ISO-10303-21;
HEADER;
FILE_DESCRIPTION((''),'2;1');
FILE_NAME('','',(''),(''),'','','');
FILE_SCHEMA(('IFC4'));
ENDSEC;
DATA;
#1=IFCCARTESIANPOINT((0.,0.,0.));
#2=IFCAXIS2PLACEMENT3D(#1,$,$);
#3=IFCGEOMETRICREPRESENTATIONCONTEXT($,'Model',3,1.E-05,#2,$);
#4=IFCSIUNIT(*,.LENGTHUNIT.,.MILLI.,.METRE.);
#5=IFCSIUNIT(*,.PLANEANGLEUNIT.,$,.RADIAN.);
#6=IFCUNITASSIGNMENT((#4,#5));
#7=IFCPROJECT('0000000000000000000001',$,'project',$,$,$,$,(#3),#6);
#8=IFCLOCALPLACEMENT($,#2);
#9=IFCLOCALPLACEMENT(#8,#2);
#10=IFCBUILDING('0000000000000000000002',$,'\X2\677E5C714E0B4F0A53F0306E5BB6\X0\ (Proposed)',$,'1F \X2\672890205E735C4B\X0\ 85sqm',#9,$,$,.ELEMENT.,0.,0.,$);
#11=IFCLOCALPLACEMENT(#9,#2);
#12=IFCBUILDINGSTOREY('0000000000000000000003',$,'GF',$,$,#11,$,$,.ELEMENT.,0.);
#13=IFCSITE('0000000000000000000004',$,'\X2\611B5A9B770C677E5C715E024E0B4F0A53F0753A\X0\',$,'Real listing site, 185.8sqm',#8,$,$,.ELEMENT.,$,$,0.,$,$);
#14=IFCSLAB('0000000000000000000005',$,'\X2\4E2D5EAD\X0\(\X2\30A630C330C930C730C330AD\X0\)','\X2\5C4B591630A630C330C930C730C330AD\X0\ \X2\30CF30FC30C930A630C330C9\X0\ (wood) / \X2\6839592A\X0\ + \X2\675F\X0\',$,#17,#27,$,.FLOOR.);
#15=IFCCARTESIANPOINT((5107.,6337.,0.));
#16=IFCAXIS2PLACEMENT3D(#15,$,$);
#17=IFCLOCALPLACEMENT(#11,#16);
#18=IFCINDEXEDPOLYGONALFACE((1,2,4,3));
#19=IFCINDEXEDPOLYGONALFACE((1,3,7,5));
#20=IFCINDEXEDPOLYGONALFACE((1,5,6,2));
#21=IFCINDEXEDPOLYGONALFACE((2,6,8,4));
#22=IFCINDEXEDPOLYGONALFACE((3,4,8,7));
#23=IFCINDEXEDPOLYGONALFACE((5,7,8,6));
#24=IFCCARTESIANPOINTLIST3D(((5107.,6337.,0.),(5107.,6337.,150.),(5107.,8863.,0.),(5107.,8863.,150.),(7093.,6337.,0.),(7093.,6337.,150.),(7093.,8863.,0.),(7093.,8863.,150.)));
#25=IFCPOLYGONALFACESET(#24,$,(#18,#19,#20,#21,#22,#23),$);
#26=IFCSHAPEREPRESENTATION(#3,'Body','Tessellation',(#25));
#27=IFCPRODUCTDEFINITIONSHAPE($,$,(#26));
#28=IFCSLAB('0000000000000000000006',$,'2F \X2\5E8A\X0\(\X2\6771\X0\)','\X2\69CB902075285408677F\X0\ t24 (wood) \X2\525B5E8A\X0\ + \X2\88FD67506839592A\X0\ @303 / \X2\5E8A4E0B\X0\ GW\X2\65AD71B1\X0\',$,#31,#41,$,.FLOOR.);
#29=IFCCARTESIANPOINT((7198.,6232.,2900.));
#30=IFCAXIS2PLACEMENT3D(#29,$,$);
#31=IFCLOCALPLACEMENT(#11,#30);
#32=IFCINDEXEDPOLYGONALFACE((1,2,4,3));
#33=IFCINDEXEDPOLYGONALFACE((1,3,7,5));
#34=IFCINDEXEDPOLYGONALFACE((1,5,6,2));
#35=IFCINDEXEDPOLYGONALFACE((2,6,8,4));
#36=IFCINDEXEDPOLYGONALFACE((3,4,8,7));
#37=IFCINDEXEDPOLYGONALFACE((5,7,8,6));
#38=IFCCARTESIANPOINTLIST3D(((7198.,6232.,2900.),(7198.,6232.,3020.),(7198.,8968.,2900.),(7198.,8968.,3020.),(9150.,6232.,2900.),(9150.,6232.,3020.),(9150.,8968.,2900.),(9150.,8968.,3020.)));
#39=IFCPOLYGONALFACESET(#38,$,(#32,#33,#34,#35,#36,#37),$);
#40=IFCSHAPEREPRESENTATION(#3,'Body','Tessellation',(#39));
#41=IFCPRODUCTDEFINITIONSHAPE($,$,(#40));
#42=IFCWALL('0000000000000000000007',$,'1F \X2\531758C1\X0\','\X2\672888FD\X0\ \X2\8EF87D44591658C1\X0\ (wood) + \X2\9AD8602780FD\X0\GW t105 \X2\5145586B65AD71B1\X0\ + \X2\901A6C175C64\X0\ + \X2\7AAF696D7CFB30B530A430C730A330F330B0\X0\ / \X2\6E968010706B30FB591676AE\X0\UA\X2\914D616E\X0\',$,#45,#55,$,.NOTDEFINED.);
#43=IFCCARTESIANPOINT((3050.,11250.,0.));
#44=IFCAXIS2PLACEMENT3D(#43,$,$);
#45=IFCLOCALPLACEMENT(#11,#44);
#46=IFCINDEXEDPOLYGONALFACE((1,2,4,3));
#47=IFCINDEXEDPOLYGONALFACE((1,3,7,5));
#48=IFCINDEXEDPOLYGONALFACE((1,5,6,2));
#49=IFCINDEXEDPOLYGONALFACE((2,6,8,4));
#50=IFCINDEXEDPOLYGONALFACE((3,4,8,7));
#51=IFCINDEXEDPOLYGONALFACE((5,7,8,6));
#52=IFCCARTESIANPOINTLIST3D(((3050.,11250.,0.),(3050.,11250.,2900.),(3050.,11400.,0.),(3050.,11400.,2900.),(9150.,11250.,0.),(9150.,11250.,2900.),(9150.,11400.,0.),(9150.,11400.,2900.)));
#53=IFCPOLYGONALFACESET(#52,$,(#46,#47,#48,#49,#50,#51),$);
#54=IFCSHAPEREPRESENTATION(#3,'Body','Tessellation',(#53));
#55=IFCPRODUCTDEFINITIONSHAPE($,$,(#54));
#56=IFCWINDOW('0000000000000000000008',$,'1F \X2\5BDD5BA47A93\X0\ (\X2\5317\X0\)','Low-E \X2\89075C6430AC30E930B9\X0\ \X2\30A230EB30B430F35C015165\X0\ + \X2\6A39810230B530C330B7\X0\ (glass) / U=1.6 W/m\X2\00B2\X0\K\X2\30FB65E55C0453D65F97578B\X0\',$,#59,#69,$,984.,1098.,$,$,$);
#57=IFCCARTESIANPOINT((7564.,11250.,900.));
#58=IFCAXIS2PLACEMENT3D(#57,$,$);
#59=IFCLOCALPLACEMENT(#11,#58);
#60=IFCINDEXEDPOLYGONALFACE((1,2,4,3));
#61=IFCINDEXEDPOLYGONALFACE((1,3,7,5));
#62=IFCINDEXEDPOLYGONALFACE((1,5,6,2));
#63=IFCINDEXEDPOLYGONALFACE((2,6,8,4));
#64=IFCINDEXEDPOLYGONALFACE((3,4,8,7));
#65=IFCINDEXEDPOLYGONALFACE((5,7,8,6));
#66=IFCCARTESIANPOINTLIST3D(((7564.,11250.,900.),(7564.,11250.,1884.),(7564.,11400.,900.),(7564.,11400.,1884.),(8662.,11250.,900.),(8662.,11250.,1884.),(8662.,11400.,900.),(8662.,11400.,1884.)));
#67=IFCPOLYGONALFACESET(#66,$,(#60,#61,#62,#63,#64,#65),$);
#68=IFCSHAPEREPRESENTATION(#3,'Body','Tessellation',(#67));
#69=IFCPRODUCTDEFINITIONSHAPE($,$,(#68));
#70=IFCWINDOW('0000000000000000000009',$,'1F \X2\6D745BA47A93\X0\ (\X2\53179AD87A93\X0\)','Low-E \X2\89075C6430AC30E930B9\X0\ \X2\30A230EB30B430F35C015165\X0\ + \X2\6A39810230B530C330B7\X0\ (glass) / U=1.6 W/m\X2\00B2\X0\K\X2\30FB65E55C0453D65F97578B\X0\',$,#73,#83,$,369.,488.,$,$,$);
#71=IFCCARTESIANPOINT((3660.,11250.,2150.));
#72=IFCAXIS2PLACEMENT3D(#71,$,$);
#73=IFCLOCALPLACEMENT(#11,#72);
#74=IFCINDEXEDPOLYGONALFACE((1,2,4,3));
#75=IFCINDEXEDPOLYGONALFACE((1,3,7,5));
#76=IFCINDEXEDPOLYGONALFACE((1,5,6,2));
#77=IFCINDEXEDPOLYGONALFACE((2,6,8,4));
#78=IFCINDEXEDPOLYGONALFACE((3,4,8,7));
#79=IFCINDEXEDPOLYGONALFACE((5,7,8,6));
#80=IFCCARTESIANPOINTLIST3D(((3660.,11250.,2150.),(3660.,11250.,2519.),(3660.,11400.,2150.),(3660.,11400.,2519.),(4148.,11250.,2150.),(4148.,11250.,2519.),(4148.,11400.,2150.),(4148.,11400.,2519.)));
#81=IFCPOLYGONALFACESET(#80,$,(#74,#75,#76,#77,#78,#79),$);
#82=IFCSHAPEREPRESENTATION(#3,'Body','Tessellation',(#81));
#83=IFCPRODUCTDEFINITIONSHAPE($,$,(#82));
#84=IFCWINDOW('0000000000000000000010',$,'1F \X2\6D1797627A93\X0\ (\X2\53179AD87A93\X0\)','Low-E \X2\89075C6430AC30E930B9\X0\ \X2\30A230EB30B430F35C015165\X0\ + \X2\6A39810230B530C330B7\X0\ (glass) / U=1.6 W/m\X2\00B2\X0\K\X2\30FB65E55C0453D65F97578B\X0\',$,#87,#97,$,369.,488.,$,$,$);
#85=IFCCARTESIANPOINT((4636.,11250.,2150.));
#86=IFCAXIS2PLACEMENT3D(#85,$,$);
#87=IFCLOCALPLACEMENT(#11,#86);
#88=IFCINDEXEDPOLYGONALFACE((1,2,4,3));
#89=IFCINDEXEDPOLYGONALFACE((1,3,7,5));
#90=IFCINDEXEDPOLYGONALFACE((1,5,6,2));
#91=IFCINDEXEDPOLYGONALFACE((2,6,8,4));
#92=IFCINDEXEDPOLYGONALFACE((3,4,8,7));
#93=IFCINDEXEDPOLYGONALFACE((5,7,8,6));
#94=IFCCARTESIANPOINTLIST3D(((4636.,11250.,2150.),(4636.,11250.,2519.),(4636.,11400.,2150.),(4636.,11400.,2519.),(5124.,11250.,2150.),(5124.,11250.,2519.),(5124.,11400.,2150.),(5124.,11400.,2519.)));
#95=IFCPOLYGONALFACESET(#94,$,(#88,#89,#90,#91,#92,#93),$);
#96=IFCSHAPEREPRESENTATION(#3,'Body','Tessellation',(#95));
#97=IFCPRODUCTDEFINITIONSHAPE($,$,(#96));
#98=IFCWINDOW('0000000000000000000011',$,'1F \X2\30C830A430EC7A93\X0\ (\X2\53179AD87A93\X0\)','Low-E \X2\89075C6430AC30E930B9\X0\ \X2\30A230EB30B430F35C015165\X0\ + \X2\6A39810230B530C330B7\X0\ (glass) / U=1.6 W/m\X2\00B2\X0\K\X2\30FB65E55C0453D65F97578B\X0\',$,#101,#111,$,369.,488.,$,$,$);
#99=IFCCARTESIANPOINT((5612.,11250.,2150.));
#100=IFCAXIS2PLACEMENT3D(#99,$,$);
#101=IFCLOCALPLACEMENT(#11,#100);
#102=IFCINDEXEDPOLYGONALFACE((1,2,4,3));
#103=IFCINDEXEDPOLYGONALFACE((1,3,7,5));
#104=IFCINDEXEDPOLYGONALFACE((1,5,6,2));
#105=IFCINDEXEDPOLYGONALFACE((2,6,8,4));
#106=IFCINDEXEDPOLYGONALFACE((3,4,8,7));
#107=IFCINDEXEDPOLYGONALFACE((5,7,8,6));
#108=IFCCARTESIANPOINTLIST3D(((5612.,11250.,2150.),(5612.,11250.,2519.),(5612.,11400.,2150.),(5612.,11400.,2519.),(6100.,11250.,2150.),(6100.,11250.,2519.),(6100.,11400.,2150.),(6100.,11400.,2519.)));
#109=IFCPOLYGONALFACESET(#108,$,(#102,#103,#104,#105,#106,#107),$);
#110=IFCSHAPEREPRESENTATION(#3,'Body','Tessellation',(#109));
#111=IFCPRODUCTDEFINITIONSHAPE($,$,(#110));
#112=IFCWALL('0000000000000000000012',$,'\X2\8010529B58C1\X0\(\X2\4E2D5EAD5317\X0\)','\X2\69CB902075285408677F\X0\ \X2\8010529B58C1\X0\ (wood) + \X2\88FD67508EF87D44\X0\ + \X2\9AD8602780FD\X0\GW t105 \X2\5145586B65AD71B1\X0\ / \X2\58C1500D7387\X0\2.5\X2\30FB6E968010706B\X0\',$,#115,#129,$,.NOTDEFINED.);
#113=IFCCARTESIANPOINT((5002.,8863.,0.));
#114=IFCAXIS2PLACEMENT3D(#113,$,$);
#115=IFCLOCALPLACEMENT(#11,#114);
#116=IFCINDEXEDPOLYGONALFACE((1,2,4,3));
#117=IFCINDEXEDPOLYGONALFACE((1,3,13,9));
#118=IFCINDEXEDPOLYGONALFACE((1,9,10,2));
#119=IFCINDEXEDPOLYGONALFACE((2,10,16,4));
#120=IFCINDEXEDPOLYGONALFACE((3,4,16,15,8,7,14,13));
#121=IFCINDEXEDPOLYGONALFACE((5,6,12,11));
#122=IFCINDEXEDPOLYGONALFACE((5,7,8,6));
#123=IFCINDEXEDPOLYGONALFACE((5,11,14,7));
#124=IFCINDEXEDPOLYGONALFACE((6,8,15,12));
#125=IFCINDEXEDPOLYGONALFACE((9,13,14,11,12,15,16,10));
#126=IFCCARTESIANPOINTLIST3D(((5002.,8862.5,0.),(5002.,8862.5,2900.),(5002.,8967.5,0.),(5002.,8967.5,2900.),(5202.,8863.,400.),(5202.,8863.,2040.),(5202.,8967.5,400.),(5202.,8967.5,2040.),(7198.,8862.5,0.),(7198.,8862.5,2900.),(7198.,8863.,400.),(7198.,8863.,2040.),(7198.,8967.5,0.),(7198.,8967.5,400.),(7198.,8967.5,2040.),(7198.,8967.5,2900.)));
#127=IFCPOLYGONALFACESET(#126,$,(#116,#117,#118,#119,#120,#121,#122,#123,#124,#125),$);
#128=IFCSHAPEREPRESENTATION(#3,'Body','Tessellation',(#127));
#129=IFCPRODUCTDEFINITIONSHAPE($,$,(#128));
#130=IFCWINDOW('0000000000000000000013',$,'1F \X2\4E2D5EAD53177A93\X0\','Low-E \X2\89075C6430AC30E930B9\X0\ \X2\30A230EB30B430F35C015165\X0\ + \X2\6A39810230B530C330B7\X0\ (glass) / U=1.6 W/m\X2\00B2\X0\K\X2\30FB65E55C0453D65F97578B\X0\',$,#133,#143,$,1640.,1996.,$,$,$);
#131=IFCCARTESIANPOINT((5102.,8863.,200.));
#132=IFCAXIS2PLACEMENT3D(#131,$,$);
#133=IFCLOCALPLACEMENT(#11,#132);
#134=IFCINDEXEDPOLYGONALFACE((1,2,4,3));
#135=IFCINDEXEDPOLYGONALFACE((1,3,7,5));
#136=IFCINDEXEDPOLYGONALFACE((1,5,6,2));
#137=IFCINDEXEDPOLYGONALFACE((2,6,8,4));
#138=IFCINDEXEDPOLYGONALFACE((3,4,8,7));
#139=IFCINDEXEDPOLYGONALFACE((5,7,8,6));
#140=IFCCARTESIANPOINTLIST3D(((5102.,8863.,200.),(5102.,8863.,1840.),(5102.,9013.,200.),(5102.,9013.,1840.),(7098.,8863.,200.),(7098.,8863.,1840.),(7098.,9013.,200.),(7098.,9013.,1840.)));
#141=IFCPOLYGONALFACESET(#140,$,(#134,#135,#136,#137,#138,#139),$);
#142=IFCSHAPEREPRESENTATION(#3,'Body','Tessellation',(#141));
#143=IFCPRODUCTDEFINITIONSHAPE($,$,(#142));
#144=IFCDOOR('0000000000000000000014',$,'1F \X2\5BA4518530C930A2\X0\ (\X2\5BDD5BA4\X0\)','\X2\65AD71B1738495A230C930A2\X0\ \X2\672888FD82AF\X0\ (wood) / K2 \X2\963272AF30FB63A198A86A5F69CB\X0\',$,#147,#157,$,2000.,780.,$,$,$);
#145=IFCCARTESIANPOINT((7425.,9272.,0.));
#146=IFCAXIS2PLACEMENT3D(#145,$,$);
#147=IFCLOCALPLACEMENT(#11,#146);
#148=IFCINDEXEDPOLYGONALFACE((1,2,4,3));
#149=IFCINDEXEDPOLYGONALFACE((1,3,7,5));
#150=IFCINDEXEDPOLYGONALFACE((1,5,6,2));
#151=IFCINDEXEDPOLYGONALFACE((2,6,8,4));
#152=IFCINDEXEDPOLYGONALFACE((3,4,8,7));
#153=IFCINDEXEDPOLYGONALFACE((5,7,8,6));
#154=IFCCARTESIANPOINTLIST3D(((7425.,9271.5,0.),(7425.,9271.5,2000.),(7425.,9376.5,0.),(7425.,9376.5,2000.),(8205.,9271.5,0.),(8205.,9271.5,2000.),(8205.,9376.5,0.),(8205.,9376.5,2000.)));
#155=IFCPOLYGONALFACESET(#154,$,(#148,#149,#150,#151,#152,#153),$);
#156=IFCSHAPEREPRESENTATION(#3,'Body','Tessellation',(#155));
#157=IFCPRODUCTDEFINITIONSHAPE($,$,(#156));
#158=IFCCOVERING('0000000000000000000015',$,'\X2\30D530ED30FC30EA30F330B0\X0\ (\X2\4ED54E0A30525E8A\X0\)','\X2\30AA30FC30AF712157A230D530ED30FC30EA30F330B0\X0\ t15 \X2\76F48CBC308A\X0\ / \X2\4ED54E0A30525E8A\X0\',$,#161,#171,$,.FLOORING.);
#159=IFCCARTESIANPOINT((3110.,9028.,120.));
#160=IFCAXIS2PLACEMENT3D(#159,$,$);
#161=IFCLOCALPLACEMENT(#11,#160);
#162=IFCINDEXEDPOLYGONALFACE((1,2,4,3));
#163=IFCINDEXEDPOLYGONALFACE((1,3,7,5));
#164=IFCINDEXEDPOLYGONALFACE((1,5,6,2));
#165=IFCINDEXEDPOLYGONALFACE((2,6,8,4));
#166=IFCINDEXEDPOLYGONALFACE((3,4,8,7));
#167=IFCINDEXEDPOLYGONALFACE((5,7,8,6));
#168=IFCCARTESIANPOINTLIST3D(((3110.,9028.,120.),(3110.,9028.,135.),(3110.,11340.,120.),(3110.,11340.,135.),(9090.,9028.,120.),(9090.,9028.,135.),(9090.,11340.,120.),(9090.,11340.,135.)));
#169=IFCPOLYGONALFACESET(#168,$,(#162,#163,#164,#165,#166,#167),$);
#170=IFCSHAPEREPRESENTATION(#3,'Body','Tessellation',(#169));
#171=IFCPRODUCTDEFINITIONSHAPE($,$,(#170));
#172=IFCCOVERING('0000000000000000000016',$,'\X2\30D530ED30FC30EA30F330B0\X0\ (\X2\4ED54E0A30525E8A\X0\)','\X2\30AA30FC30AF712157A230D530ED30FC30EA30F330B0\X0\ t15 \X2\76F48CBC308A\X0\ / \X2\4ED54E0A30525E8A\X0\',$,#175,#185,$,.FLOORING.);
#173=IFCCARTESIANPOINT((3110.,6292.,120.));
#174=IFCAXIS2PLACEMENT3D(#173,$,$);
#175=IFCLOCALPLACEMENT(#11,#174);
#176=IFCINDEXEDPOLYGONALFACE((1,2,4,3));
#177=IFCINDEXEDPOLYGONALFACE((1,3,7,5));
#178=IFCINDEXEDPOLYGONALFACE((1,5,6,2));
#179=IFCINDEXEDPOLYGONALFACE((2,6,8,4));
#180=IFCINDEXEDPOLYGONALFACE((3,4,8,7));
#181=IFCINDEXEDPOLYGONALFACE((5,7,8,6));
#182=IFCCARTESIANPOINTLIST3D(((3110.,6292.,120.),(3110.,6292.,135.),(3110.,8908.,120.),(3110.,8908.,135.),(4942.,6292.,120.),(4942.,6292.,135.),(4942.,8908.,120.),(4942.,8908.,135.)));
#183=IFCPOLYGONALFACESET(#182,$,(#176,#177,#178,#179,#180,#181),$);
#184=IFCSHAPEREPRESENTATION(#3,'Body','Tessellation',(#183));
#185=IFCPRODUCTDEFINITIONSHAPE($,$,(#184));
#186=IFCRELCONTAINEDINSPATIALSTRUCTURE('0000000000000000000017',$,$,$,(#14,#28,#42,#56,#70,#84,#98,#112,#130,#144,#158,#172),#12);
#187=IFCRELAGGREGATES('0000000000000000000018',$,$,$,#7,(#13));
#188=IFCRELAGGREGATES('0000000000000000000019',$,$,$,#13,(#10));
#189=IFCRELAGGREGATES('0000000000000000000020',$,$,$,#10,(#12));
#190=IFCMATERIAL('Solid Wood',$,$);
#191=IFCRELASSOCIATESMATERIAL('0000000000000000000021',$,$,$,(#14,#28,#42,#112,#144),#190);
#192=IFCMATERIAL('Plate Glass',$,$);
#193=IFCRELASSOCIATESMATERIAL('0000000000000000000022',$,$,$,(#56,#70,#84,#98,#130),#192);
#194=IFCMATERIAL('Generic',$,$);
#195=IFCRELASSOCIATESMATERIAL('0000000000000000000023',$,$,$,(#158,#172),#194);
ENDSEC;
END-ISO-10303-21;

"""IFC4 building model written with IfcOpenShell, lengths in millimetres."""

from ifc_helpers import new_model, si_unit, frame, frame_2d, origin, place, context, project, spatial, rectangle, extrude, material, element, fill, save


model = new_model("IFC4")

# Units and contexts
model_context = context("Model", 3, precision=1e-05, world=origin())
ifc_project = project(units=[si_unit("LENGTHUNIT", "METRE", prefix="MILLI"), si_unit("PLANEANGLEUNIT", "RADIAN")], contexts=[model_context])

# Site, building, storey
site_placement = place(None, origin())
site = spatial("IfcSite", under=ifc_project, at=site_placement, Name="愛媛県松山市下伊台町", ObjectType="Real listing site, 185.8sqm", CompositionType="ELEMENT", RefElevation=0.0)
building_placement = place(site_placement, origin())
building = spatial("IfcBuilding", under=site, at=building_placement, Name="松山下伊台の家 (Proposed)", ObjectType="1F 木造平屋 85sqm", CompositionType="ELEMENT", ElevationOfRefHeight=0.0, ElevationOfTerrain=0.0)
storey_placement = place(building_placement, origin())
storey = spatial("IfcBuildingStorey", under=building, at=storey_placement, Name="GF", CompositionType="ELEMENT", Elevation=0.0)

# Slabs
ifc_material_1 = material(Name="Solid Wood")
slab_1_placement = place(storey_placement, frame((5107.0, 6337.0, 0.0)))
element("IfcSlab", 1, at=slab_1_placement, inside=storey, material=ifc_material_1, Name="中庭(ウッドデッキ)", Description="屋外ウッドデッキ ハードウッド (wood) / 根太 + 束", PredefinedType="FLOOR", context=model_context, shape_type="SweptSolid", body=[
    extrude(rectangle(XDim=1986.0, YDim=2526.0, at=frame_2d((993.0, 1263.0))), frame((5107.0, 6337.0, 0.0)), (0.0, 0.0, 1.0), 150.0),
])
slab_2_placement = place(storey_placement, frame((7198.0, 6232.0, 2900.0)))
element("IfcSlab", 2, at=slab_2_placement, inside=storey, material=ifc_material_1, Name="2F 床(東)", Description="構造用合板 t24 (wood) 剛床 + 製材根太 @303 / 床下 GW断熱", PredefinedType="FLOOR", context=model_context, shape_type="SweptSolid", body=[
    extrude(rectangle(XDim=1952.0, YDim=2736.0, at=frame_2d((976.0, 1368.0))), frame((7198.0, 6232.0, 2900.0)), (0.0, 0.0, 1.0), 120.0),
])

# Wall, openings, windows
wall_1_placement = place(storey_placement, frame((3050.0, 11250.0, 0.0)))
wall_1 = element("IfcWall", 3, at=wall_1_placement, inside=storey, material=ifc_material_1, Name="1F 北壁", Description="木製 軸組外壁 (wood) + 高性能GW t105 充填断熱 + 通気層 + 窯業系サイディング / 準耐火・外皮UA配慮", PredefinedType="NOTDEFINED", context=model_context, shape_type="SweptSolid", body=[
    extrude(rectangle(XDim=6100.0, YDim=150.0, at=frame_2d((3050.0, 75.0))), frame((3050.0, 11250.0, 0.0)), (0.0, 0.0, 1.0), 2900.0),
])
opening_1_placement = place(storey_placement, frame((7564.0, 11250.0, 900.0)))
opening_1 = element("IfcOpeningElement", 4, at=opening_1_placement, cuts=wall_1, PredefinedType="NOTDEFINED", context=model_context, shape_type="SweptSolid", body=[
    extrude(rectangle(XDim=1098.0, YDim=150.0, at=frame_2d((549.0, 75.0))), frame((7564.0, 11250.0, 900.0)), (0.0, 0.0, 1.0), 984.0),
])
opening_2_placement = place(storey_placement, frame((3660.0, 11250.0, 2150.0)))
opening_2 = element("IfcOpeningElement", 5, at=opening_2_placement, cuts=wall_1, PredefinedType="NOTDEFINED", context=model_context, shape_type="SweptSolid", body=[
    extrude(rectangle(XDim=488.0, YDim=150.0, at=frame_2d((244.0, 75.0))), frame((3660.0, 11250.0, 2150.0)), (0.0, 0.0, 1.0), 369.0),
])
opening_3_placement = place(storey_placement, frame((4636.0, 11250.0, 2150.0)))
opening_3 = element("IfcOpeningElement", 6, at=opening_3_placement, cuts=wall_1, PredefinedType="NOTDEFINED", context=model_context, shape_type="SweptSolid", body=[
    extrude(rectangle(XDim=488.0, YDim=150.0, at=frame_2d((244.0, 75.0))), frame((4636.0, 11250.0, 2150.0)), (0.0, 0.0, 1.0), 369.0),
])
opening_4_placement = place(storey_placement, frame((5612.0, 11250.0, 2150.0)))
opening_4 = element("IfcOpeningElement", 7, at=opening_4_placement, cuts=wall_1, PredefinedType="NOTDEFINED", context=model_context, shape_type="SweptSolid", body=[
    extrude(rectangle(XDim=488.0, YDim=150.0, at=frame_2d((244.0, 75.0))), frame((5612.0, 11250.0, 2150.0)), (0.0, 0.0, 1.0), 369.0),
])
ifc_material_2 = material(Name="Plate Glass")
window_1_placement = place(storey_placement, frame((7564.0, 11250.0, 900.0)))
window_1 = element("IfcWindow", 8, at=window_1_placement, inside=storey, material=ifc_material_2, Name="1F 寝室窓 (北)", Description="Low-E 複層ガラス アルゴン封入 + 樹脂サッシ (glass) / U=1.6 W/m²K・日射取得型", OverallHeight=984.0, OverallWidth=1098.0, context=model_context, shape_type="SweptSolid", body=[
    extrude(rectangle(XDim=1098.0, YDim=150.0, at=frame_2d((549.0, 75.0))), frame((7564.0, 11250.0, 900.0)), (0.0, 0.0, 1.0), 984.0),
])
fill(opening_1, window_1)
window_2_placement = place(storey_placement, frame((3660.0, 11250.0, 2150.0)))
window_2 = element("IfcWindow", 9, at=window_2_placement, inside=storey, material=ifc_material_2, Name="1F 浴室窓 (北高窓)", Description="Low-E 複層ガラス アルゴン封入 + 樹脂サッシ (glass) / U=1.6 W/m²K・日射取得型", OverallHeight=369.0, OverallWidth=488.0, context=model_context, shape_type="SweptSolid", body=[
    extrude(rectangle(XDim=488.0, YDim=150.0, at=frame_2d((244.0, 75.0))), frame((3660.0, 11250.0, 2150.0)), (0.0, 0.0, 1.0), 369.0),
])
fill(opening_2, window_2)
window_3_placement = place(storey_placement, frame((4636.0, 11250.0, 2150.0)))
window_3 = element("IfcWindow", 10, at=window_3_placement, inside=storey, material=ifc_material_2, Name="1F 洗面窓 (北高窓)", Description="Low-E 複層ガラス アルゴン封入 + 樹脂サッシ (glass) / U=1.6 W/m²K・日射取得型", OverallHeight=369.0, OverallWidth=488.0, context=model_context, shape_type="SweptSolid", body=[
    extrude(rectangle(XDim=488.0, YDim=150.0, at=frame_2d((244.0, 75.0))), frame((4636.0, 11250.0, 2150.0)), (0.0, 0.0, 1.0), 369.0),
])
fill(opening_3, window_3)
window_4_placement = place(storey_placement, frame((5612.0, 11250.0, 2150.0)))
window_4 = element("IfcWindow", 11, at=window_4_placement, inside=storey, material=ifc_material_2, Name="1F トイレ窓 (北高窓)", Description="Low-E 複層ガラス アルゴン封入 + 樹脂サッシ (glass) / U=1.6 W/m²K・日射取得型", OverallHeight=369.0, OverallWidth=488.0, context=model_context, shape_type="SweptSolid", body=[
    extrude(rectangle(XDim=488.0, YDim=150.0, at=frame_2d((244.0, 75.0))), frame((5612.0, 11250.0, 2150.0)), (0.0, 0.0, 1.0), 369.0),
])
fill(opening_4, window_4)

# Wall, opening, window
wall_2_placement = place(storey_placement, frame((5002.0, 8863.0, 0.0)))
wall_2 = element("IfcWall", 12, at=wall_2_placement, inside=storey, material=ifc_material_1, Name="耐力壁(中庭北)", Description="構造用合板 耐力壁 (wood) + 製材軸組 + 高性能GW t105 充填断熱 / 壁倍率2.5・準耐火", PredefinedType="NOTDEFINED", context=model_context, shape_type="SweptSolid", body=[
    extrude(rectangle(XDim=2196.0, YDim=105.0, at=frame_2d((1098.0, 52.0))), frame((5002.0, 8863.0, 0.0)), (0.0, 0.0, 1.0), 2900.0),
])
opening_5_placement = place(storey_placement, frame((5102.0, 8863.0, 200.0)))
opening_5 = element("IfcOpeningElement", 13, at=opening_5_placement, cuts=wall_2, PredefinedType="NOTDEFINED", context=model_context, shape_type="SweptSolid", body=[
    extrude(rectangle(XDim=1996.0, YDim=150.0, at=frame_2d((998.0, 75.0))), frame((5102.0, 8863.0, 200.0)), (0.0, 0.0, 1.0), 1640.0),
])
window_5_placement = place(storey_placement, frame((5102.0, 8863.0, 200.0)))
window_5 = element("IfcWindow", 14, at=window_5_placement, inside=storey, material=ifc_material_2, Name="1F 中庭北窓", Description="Low-E 複層ガラス アルゴン封入 + 樹脂サッシ (glass) / U=1.6 W/m²K・日射取得型", OverallHeight=1640.0, OverallWidth=1996.0, context=model_context, shape_type="SweptSolid", body=[
    extrude(rectangle(XDim=1996.0, YDim=150.0, at=frame_2d((998.0, 75.0))), frame((5102.0, 8863.0, 200.0)), (0.0, 0.0, 1.0), 1640.0),
])
fill(opening_5, window_5)

# Door
door_1_placement = place(storey_placement, frame((7425.0, 9272.0, 0.0)))
element("IfcDoor", 15, at=door_1_placement, inside=storey, material=ifc_material_1, Name="1F 室内ドア (寝室)", Description="断熱玄関ドア 木製芯 (wood) / K2 防犯・採風機構", OverallHeight=2000.0, OverallWidth=780.0, context=model_context, shape_type="SweptSolid", body=[
    extrude(rectangle(XDim=780.0, YDim=105.0, at=frame_2d((390.0, 52.0))), frame((7425.0, 9272.0, 0.0)), (0.0, 0.0, 1.0), 2000.0),
])

# Coverings
ifc_material_3 = material(Name="Generic")
covering_1_placement = place(storey_placement, frame((3110.0, 9028.0, 120.0)))
element("IfcCovering", 16, at=covering_1_placement, inside=storey, material=ifc_material_3, Name="フローリング (仕上げ床)", Description="オーク無垢フローリング t15 直貼り / 仕上げ床", PredefinedType="FLOORING", context=model_context, shape_type="SweptSolid", body=[
    extrude(rectangle(XDim=5980.0, YDim=2312.0, at=frame_2d((2990.0, 1156.0))), frame((3110.0, 9028.0, 120.0)), (0.0, 0.0, 1.0), 15.0),
])
covering_2_placement = place(storey_placement, frame((3110.0, 6292.0, 120.0)))
element("IfcCovering", 17, at=covering_2_placement, inside=storey, material=ifc_material_3, Name="フローリング (仕上げ床)", Description="オーク無垢フローリング t15 直貼り / 仕上げ床", PredefinedType="FLOORING", context=model_context, shape_type="SweptSolid", body=[
    extrude(rectangle(XDim=1832.0, YDim=2616.0, at=frame_2d((916.0, 1308.0))), frame((3110.0, 6292.0, 120.0)), (0.0, 0.0, 1.0), 15.0),
])

save(model, "model.ifc")
